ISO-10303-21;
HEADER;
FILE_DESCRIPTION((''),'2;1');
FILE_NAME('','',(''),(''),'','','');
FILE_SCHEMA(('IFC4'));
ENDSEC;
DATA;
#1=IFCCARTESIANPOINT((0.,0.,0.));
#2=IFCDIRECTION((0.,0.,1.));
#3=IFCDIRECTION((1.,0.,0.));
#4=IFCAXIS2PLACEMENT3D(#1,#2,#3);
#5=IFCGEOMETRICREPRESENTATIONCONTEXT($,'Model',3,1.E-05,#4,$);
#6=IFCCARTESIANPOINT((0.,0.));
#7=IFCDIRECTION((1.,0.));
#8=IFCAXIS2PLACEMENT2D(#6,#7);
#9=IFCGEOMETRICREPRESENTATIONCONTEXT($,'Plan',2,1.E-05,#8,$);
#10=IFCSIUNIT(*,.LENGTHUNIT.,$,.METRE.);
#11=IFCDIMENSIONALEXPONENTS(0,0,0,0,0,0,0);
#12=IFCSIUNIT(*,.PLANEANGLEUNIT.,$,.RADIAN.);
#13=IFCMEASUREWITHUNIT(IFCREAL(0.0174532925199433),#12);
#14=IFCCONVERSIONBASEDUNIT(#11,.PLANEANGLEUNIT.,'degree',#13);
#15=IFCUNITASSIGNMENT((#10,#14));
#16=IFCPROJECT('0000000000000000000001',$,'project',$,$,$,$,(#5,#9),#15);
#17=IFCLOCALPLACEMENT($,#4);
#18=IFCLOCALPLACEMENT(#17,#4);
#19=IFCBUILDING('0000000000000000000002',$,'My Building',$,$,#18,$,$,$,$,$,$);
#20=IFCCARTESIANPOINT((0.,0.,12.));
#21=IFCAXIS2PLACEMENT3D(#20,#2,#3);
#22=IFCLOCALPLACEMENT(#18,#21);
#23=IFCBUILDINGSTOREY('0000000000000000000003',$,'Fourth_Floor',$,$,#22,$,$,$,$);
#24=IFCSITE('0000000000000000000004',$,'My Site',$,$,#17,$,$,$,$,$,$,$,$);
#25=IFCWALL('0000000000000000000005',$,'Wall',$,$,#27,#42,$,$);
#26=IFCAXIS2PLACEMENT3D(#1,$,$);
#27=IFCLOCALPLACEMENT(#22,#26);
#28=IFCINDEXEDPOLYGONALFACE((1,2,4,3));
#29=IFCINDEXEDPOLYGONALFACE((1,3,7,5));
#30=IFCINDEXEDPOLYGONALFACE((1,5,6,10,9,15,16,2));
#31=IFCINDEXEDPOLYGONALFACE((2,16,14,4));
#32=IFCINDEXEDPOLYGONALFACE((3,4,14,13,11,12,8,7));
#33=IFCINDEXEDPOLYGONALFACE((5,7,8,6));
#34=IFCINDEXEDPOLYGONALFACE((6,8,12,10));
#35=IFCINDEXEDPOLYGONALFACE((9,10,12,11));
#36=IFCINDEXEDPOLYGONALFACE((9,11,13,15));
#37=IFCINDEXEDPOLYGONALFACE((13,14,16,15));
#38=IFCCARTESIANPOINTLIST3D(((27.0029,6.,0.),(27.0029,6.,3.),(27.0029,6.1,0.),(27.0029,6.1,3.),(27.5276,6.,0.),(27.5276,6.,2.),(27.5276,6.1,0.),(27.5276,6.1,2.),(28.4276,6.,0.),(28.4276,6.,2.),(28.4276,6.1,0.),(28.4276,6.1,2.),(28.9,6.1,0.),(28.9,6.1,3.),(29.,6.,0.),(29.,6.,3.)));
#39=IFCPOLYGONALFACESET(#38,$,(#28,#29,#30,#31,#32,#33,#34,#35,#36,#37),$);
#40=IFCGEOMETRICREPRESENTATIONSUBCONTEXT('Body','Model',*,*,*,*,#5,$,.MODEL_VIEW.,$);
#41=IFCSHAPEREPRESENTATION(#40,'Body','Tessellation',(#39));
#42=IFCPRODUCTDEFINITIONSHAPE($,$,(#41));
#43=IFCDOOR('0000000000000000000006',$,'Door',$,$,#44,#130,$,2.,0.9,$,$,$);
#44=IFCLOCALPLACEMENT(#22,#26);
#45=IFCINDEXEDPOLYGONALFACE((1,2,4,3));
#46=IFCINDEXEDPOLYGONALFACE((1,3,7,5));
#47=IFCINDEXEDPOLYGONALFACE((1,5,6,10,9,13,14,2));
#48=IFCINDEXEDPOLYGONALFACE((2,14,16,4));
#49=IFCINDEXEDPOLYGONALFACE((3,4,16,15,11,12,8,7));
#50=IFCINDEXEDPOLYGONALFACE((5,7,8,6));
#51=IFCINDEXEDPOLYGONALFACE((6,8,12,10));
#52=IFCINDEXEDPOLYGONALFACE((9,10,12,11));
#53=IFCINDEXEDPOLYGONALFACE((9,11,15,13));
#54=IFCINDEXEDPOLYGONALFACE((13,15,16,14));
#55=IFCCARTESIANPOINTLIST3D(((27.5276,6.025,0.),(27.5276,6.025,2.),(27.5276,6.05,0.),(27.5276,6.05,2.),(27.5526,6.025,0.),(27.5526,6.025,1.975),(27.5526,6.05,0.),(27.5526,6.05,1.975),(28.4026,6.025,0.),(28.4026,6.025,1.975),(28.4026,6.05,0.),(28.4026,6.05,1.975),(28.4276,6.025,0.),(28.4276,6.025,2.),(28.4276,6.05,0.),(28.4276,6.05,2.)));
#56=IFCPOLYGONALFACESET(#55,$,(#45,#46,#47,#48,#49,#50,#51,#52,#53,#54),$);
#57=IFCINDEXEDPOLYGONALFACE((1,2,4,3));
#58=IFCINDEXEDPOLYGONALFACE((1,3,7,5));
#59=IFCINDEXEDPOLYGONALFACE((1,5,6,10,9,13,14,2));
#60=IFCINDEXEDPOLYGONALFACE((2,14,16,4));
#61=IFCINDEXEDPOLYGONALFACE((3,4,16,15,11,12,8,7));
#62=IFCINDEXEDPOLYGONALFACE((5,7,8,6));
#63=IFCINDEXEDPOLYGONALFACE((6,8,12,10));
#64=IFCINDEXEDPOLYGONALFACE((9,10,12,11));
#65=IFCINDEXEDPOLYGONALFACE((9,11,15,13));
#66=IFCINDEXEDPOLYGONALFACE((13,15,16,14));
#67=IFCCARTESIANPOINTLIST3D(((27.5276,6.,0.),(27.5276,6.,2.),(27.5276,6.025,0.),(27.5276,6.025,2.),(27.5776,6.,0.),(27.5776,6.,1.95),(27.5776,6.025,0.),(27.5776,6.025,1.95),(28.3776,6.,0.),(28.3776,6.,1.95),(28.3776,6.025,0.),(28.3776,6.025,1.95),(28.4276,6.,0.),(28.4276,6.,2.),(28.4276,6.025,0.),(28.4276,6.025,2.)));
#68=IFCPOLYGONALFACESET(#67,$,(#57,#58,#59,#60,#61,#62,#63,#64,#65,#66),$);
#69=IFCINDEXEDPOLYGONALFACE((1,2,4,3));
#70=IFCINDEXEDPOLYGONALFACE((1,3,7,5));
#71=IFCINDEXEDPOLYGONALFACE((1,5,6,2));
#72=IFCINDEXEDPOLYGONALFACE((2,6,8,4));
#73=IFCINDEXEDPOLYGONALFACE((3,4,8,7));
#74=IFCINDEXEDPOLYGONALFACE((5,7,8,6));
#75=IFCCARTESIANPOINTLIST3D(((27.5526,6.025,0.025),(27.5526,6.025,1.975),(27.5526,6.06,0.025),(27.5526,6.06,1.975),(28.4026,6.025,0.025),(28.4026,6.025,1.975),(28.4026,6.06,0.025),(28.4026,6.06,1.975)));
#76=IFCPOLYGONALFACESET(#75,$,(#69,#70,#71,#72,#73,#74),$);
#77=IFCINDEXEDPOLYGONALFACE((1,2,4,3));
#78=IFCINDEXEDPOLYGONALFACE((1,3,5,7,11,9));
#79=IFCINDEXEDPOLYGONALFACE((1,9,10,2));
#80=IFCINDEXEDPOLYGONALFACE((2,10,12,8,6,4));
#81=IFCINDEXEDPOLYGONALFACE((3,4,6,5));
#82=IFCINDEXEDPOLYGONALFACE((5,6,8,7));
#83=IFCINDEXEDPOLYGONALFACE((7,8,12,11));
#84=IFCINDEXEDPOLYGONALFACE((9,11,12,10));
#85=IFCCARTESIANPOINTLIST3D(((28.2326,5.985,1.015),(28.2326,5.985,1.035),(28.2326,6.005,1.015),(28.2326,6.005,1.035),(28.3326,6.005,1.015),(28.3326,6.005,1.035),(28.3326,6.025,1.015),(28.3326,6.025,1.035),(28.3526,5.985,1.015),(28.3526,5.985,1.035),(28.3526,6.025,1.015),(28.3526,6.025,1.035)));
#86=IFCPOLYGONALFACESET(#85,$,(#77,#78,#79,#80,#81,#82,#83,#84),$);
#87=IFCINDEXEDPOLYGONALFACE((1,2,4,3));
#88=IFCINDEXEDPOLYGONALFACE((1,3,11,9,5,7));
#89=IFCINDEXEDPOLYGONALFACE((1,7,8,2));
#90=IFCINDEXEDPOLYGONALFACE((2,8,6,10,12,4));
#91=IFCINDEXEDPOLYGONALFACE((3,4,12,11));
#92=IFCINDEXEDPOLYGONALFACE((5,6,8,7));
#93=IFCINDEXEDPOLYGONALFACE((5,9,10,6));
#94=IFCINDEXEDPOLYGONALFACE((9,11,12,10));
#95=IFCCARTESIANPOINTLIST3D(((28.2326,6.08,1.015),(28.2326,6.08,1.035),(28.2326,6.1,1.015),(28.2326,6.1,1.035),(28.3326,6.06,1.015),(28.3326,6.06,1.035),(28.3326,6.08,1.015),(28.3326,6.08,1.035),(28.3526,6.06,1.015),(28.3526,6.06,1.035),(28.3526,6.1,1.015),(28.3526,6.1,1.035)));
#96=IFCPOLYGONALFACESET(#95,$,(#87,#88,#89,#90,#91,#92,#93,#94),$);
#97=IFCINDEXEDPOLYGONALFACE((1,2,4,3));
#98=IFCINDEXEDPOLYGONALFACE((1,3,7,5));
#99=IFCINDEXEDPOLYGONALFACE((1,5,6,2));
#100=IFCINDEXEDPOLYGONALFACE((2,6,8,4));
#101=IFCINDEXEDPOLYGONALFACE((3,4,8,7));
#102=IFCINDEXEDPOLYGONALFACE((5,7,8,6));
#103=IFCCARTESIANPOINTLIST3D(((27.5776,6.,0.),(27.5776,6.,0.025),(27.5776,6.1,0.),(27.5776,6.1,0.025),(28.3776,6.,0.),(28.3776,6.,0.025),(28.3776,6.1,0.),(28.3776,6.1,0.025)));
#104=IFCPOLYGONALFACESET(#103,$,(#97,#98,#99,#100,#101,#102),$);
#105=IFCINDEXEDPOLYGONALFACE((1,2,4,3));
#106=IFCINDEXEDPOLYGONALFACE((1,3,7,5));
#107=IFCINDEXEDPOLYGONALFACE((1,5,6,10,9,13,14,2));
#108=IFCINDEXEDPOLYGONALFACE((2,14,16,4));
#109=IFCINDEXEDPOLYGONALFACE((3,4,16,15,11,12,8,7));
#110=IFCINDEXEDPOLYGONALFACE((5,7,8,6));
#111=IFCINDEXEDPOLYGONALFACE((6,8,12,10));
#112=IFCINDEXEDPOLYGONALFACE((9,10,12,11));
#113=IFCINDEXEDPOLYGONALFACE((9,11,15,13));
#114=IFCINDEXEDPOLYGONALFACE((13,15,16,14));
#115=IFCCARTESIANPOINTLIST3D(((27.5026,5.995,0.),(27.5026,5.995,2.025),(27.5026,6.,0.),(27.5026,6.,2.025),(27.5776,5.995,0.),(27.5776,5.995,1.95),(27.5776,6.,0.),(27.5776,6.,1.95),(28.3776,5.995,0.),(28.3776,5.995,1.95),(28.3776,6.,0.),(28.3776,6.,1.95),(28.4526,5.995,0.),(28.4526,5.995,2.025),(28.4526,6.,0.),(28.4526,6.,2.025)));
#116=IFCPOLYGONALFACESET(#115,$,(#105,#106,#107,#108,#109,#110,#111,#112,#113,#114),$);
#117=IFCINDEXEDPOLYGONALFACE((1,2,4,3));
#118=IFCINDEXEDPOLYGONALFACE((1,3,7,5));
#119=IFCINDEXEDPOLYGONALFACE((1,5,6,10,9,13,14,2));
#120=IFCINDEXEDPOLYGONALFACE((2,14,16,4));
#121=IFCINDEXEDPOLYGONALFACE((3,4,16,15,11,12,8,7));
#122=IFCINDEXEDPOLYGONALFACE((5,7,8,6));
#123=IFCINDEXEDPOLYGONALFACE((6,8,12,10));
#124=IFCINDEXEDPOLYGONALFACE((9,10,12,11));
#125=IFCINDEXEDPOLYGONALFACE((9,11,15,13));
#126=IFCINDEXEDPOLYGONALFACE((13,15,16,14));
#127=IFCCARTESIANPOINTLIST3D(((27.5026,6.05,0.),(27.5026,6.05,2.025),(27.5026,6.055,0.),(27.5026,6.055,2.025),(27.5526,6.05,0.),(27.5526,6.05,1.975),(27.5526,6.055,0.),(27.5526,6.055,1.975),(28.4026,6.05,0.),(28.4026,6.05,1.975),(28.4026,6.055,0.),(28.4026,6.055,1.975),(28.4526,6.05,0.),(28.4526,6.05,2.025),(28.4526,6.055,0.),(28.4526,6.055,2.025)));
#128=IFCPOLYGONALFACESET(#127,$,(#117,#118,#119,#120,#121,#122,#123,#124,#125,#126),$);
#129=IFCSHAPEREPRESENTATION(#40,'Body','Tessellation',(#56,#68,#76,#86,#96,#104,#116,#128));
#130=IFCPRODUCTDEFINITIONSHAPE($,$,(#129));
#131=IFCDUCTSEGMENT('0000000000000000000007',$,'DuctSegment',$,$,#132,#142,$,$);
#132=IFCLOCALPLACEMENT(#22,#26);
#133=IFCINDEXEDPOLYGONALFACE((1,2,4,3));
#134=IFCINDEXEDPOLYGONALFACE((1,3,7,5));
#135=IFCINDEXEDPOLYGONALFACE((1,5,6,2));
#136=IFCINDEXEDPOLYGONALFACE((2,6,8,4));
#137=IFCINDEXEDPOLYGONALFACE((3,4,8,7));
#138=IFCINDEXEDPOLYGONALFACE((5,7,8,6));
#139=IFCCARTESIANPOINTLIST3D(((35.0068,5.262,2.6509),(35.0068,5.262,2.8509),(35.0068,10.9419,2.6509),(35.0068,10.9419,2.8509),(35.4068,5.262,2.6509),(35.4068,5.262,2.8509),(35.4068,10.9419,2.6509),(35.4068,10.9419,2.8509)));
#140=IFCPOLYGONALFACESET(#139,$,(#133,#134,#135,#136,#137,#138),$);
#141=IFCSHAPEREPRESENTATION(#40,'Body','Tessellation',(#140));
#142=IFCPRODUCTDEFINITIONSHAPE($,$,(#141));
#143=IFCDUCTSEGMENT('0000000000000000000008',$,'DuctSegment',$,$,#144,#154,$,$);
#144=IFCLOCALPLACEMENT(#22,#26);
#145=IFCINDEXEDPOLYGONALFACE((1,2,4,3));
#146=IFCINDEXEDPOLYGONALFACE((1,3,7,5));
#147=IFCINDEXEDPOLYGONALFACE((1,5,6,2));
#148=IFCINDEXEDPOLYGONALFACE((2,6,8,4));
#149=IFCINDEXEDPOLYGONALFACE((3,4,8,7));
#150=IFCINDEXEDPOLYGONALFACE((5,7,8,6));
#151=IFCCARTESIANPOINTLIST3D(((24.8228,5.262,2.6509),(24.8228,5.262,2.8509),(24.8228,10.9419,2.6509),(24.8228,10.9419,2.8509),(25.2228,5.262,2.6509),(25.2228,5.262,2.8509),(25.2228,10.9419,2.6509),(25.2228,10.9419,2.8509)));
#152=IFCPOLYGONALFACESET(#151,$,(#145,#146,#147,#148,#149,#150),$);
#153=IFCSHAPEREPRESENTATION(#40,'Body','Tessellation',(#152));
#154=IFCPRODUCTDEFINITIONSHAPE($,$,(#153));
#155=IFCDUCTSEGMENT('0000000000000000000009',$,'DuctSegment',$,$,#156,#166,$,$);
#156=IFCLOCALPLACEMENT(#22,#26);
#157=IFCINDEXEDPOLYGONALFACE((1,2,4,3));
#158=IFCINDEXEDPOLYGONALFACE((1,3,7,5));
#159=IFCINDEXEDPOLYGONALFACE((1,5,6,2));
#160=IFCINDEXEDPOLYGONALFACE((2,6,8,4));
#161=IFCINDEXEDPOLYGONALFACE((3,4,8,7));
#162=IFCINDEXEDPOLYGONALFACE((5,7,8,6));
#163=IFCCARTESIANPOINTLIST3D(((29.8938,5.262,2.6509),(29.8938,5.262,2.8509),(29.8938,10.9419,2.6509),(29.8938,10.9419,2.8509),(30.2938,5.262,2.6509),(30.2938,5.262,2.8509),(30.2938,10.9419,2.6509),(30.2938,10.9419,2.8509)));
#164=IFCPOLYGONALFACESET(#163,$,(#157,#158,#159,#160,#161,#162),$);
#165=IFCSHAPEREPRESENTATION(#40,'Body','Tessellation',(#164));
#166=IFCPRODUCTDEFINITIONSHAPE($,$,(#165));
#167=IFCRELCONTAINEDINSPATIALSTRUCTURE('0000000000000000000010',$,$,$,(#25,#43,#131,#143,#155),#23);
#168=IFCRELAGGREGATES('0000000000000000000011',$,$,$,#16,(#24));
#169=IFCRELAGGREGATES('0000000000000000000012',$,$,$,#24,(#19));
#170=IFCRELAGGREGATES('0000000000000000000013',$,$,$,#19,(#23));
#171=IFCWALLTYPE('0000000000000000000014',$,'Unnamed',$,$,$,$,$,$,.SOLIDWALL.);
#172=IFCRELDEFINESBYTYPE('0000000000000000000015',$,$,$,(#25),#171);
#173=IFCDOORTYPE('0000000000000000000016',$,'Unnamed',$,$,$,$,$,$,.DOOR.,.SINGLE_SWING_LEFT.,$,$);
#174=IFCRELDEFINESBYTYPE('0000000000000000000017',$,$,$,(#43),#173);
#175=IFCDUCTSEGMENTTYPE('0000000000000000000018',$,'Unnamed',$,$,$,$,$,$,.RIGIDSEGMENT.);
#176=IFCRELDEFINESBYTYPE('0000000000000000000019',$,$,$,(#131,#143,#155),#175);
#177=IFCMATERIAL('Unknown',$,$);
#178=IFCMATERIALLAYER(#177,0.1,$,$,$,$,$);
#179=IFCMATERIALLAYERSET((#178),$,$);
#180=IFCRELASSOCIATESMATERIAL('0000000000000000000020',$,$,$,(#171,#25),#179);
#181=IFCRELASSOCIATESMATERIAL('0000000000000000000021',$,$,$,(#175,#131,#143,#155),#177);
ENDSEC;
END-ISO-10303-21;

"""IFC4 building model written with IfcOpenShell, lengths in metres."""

from ifc_helpers import new_model, entity, si_unit, converted_unit, frame, origin_with_axes, origin_2d_with_axis, place, context, subcontext, project, spatial, line, indexed_curve, rectangle, outline, extrude, shape, source, transform, mapped, material, layer, layer_set, layer_usage, material_profile, profile_set, profile_usage, type_object, type_shapes, element, fill, save


model = new_model("IFC4")

# Units and contexts
model_context = context("Model", 3, precision=1e-05, world=origin_with_axes())
plan_context = context("Plan", 2, precision=1e-05, world=origin_2d_with_axis())
body_context_1 = subcontext(model_context, "Body", "Model", "MODEL_VIEW")
body_context_2 = subcontext(plan_context, "Body", "Plan", "PLAN_VIEW")
ifc_project = project(units=[si_unit("LENGTHUNIT", "METRE"), converted_unit("PLANEANGLEUNIT", "degree", entity("IfcReal", 0.0174532925199433), si_unit("PLANEANGLEUNIT", "RADIAN"), dimensions=[0, 0, 0, 0, 0, 0, 0])], contexts=[model_context, plan_context])

# Site, building, storey
site_placement = place(None, origin_with_axes())
site = spatial("IfcSite", under=ifc_project, at=site_placement, Name="My Site")
building_placement = place(site_placement, origin_with_axes())
building = spatial("IfcBuilding", under=site, at=building_placement, Name="My Building")
storey_placement = place(building_placement, frame((0.0, 0.0, 12.0), z_axis=(0.0, 0.0, 1.0), x_axis=(1.0, 0.0, 0.0)))
storey = spatial("IfcBuildingStorey", under=building, at=storey_placement, Name="Fourth_Floor")

# Shared definitions
ifc_material = material(Name="Unknown")
ifc_layer = layer(ifc_material, 0.1)
ifc_layer_set = layer_set([ifc_layer])
wall_type = type_object("IfcWallType", Name="Unnamed", PredefinedType="SOLIDWALL", material=ifc_layer_set)

# Shared definitions
shared_shape_1 = source(origin_with_axes(), body_context_1, "Body", "SweptSolid", [
    extrude(outline(indexed_curve([(0.0, 0.0), (0.9, 0.0), (0.9, 2.0), (0.0, 2.0)], segments=[line(1, 2, 3, 4, 1)])), frame((0.0, -0.6, 0.0), z_axis=(0.0, -1.0, 0.0), x_axis=(1.0, 0.0, 0.0)), (0.0, 0.0, -1.0), 1.2),
])
door_type = type_object("IfcDoorType", Name="Unnamed", OperationType="SINGLE_SWING_LEFT", PredefinedType="DOOR")
shared_shape_2 = source(origin_with_axes(), body_context_1, "Body", "SweptSolid", [
    extrude(outline(indexed_curve([(0.0, 0.0), (0.0, 2.0), (0.9, 2.0), (0.9, 0.0), (0.875, 0.0), (0.875, 1.975), (0.025, 1.975), (0.025, 0.0)], segments=[line(1, 2, 3, 4, 5, 6, 7, 8, 1)])), frame((0.0, 0.025, 0.0), z_axis=(0.0, -1.0, 0.0), x_axis=(1.0, 0.0, 0.0)), (0.0, 0.0, -1.0), 0.025),
    extrude(outline(indexed_curve([(0.0, 0.0), (0.0, 2.0), (0.9, 2.0), (0.9, 0.0), (0.85, 0.0), (0.85, 1.95), (0.05, 1.95), (0.05, 0.0)], segments=[line(1, 2, 3, 4, 5, 6, 7, 8, 1)])), frame((0.0, 0.0, 0.0), z_axis=(0.0, -1.0, 0.0), x_axis=(1.0, 0.0, 0.0)), (0.0, 0.0, -1.0), 0.025),
    extrude(outline(indexed_curve([(0.0, 0.0), (0.85, 0.0), (0.85, 0.035), (0.0, 0.035)], segments=[line(1, 2, 3, 4, 1)])), frame((0.025, 0.025, 0.025), z_axis=(0.0, 0.0, 1.0), x_axis=(1.0, 0.0, 0.0)), (0.0, 0.0, 1.0), 1.95),
    extrude(outline(indexed_curve([(0.0, 0.0), (0.0, -0.04), (-0.12, -0.04), (-0.12, -0.02), (-0.02, -0.02), (-0.02, 0.0)], segments=[line(1, 2, 3, 4, 5, 6, 1)])), frame((0.825, 0.025, 1.015), z_axis=(0.0, 0.0, 1.0), x_axis=(1.0, 0.0, 0.0)), (0.0, 0.0, 1.0), 0.02),
    extrude(outline(indexed_curve([(0.0, 0.0), (0.0, 0.04), (-0.12, 0.04), (-0.12, 0.02), (-0.02, 0.02), (-0.02, 0.0)], segments=[line(1, 2, 3, 4, 5, 6, 1)])), frame((0.825, 0.06, 1.015), z_axis=(0.0, 0.0, 1.0), x_axis=(1.0, 0.0, 0.0)), (0.0, 0.0, 1.0), 0.02),
    extrude(outline(indexed_curve([(0.0, 0.0), (0.8, 0.0), (0.8, 0.1), (0.0, 0.1)], segments=[line(1, 2, 3, 4, 1)])), frame((0.05, 0.0, 0.0), z_axis=(0.0, 0.0, 1.0), x_axis=(1.0, 0.0, 0.0)), (0.0, 0.0, 1.0), 0.025),
    extrude(outline(indexed_curve([(0.0, 0.0), (0.0, 2.025), (0.95, 2.025), (0.95, 0.0), (0.875, 0.0), (0.875, 1.95), (0.075, 1.95), (0.075, 0.0)], segments=[line(1, 2, 3, 4, 5, 6, 7, 8, 1)])), frame((-0.025, -0.005, 0.0), z_axis=(0.0, -1.0, 0.0), x_axis=(1.0, 0.0, 0.0)), (0.0, 0.0, -1.0), 0.005),
    extrude(outline(indexed_curve([(0.0, 0.0), (0.0, 2.025), (0.95, 2.025), (0.95, 0.0), (0.9, 0.0), (0.9, 1.975), (0.05, 1.975), (0.05, 0.0)], segments=[line(1, 2, 3, 4, 5, 6, 7, 8, 1)])), frame((-0.025, 0.05, 0.0), z_axis=(0.0, -1.0, 0.0), x_axis=(1.0, 0.0, 0.0)), (0.0, 0.0, -1.0), 0.005),
])
shared_shape_3 = source(origin_with_axes(), body_context_2, "Body", "Curve2D", [
    entity("IfcIndexedPolyCurve", entity("IfcCartesianPointList2D", [[0.0, 0.0], [0.0, 0.05], [0.025, 0.05], [0.025, 0.025], [0.05, 0.025], [0.05, 0.0]]), [entity("IfcLineIndex", [1, 2, 3, 4, 5, 6, 1])]),
    entity("IfcIndexedPolyCurve", entity("IfcCartesianPointList2D", [[0.9, 0.0], [0.9, 0.05], [0.875, 0.05], [0.875, 0.025], [0.85, 0.025], [0.85, 0.0]]), [entity("IfcLineIndex", [1, 2, 3, 4, 5, 6, 1])]),
    entity("IfcTrimmedCurve", entity("IfcEllipse", entity("IfcAxis2Placement2D", entity("IfcCartesianPoint", [0.06, 0.05]), entity("IfcDirection", [1.0, 0.0])), 0.815, 0.85), [entity("IfcCartesianPoint", [0.875, 0.05])], [entity("IfcCartesianPoint", [0.06, 0.9])], True, "CARTESIAN"),
    entity("IfcIndexedPolyCurve", entity("IfcCartesianPointList2D", [[0.025, 0.05], [0.06, 0.05], [0.06, 0.9], [0.025, 0.9]]), [entity("IfcLineIndex", [1, 2, 3, 4, 1])]),
])
type_shapes(door_type, [shared_shape_2, shared_shape_3])

# Wall, opening, door
ifc_layer_usage_1 = layer_usage(ifc_layer_set, "AXIS2", "POSITIVE", 0.0)
wall_1_placement = place(storey_placement, frame((27.0029, 6.0, 0.0), z_axis=(0.0, 0.0, 1.0), x_axis=(1.0, 0.0, 0.0)))
wall_1 = element("IfcWall", 1, at=wall_1_placement, inside=storey, type_object=wall_type, material=ifc_layer_usage_1, Name="Wall", context=body_context_1, shape_type="SweptSolid", body=[
    extrude(outline(indexed_curve([(0.0, 0.0), (0.0, 0.1), (1.8971, 0.1), (1.9971, 0.0)], segments=[line(1, 2, 3, 4, 1)])), origin_with_axes(), (0.0, 0.0, 1.0), 3.0),
])
opening_1_placement = place(wall_1_placement, frame((0.5247, 0.0, 0.0), z_axis=(0.0, 0.0, 1.0), x_axis=(1.0, 0.0, 0.0)))
opening_1 = element("IfcOpeningElement", 2, at=opening_1_placement, cuts=wall_1, PredefinedType="OPENING", context=body_context_1, shape_type="MappedRepresentation", body=[
    mapped(shared_shape_1, transform((0.0, 0.0, 0.0), x_axis=(1.0, 0.0, 0.0), y_axis=(0.0, 1.0, 0.0), z_axis=(0.0, 0.0, 1.0), scale=1.0)),
])
door_1_placement = place(opening_1_placement, origin_with_axes())
door_1 = element("IfcDoor", 3, at=door_1_placement, inside=storey, type_object=door_type, Name="Door", OverallHeight=2.0, OverallWidth=0.9, shapes=[
    shape(body_context_1, "Body", "MappedRepresentation", [mapped(shared_shape_2, transform((0.0, 0.0, 0.0), x_axis=(1.0, 0.0, 0.0), y_axis=(0.0, 1.0, 0.0), z_axis=(0.0, 0.0, 1.0), scale=1.0))]),
    shape(body_context_2, "Body", "MappedRepresentation", [mapped(shared_shape_3, transform((0.0, 0.0, 0.0), x_axis=(1.0, 0.0, 0.0), y_axis=(0.0, 1.0, 0.0), z_axis=(0.0, 0.0, 1.0), scale=1.0))]),
])
fill(opening_1, door_1)

# Duct segments
ifc_material_profile_1 = material_profile(ifc_material, rectangle(XDim=0.4, YDim=0.2))
ifc_profile_set_1 = profile_set([ifc_material_profile_1])
ifc_profile_usage_1 = profile_usage(ifc_profile_set_1, cardinal=5)
duct_segment_type = type_object("IfcDuctSegmentType", Name="Unnamed", PredefinedType="RIGIDSEGMENT", material=ifc_profile_set_1)
duct_segment_1_placement = place(storey_placement, frame((35.2068, 5.262, 2.7509), z_axis=(0.0, 1.0, 0.0), x_axis=(-1.0, 0.0, 0.0)))
element("IfcDuctSegment", 4, at=duct_segment_1_placement, inside=storey, type_object=duct_segment_type, material=ifc_profile_usage_1, Name="DuctSegment", context=body_context_1, shape_type="SweptSolid", body=[
    extrude(rectangle(XDim=0.4, YDim=0.2), origin_with_axes(), (0.0, 0.0, 1.0), 5.6799),
])
ifc_profile_usage_2 = profile_usage(ifc_profile_set_1, cardinal=5)
duct_segment_2_placement = place(storey_placement, frame((25.0228, 5.262, 2.7509), z_axis=(0.0, 1.0, 0.0), x_axis=(-1.0, 0.0, 0.0)))
element("IfcDuctSegment", 5, at=duct_segment_2_placement, inside=storey, type_object=duct_segment_type, material=ifc_profile_usage_2, Name="DuctSegment", context=body_context_1, shape_type="SweptSolid", body=[
    extrude(rectangle(XDim=0.4, YDim=0.2), origin_with_axes(), (0.0, 0.0, 1.0), 5.6799),
])
ifc_profile_usage_3 = profile_usage(ifc_profile_set_1, cardinal=5)
duct_segment_3_placement = place(storey_placement, frame((30.0938, 5.262, 2.7509), z_axis=(0.0, 1.0, 0.0), x_axis=(-1.0, 0.0, 0.0)))
element("IfcDuctSegment", 6, at=duct_segment_3_placement, inside=storey, type_object=duct_segment_type, material=ifc_profile_usage_3, Name="DuctSegment", context=body_context_1, shape_type="SweptSolid", body=[
    extrude(rectangle(XDim=0.4, YDim=0.2), origin_with_axes(), (0.0, 0.0, 1.0), 5.6799),
])

save(model, "model.ifc")
